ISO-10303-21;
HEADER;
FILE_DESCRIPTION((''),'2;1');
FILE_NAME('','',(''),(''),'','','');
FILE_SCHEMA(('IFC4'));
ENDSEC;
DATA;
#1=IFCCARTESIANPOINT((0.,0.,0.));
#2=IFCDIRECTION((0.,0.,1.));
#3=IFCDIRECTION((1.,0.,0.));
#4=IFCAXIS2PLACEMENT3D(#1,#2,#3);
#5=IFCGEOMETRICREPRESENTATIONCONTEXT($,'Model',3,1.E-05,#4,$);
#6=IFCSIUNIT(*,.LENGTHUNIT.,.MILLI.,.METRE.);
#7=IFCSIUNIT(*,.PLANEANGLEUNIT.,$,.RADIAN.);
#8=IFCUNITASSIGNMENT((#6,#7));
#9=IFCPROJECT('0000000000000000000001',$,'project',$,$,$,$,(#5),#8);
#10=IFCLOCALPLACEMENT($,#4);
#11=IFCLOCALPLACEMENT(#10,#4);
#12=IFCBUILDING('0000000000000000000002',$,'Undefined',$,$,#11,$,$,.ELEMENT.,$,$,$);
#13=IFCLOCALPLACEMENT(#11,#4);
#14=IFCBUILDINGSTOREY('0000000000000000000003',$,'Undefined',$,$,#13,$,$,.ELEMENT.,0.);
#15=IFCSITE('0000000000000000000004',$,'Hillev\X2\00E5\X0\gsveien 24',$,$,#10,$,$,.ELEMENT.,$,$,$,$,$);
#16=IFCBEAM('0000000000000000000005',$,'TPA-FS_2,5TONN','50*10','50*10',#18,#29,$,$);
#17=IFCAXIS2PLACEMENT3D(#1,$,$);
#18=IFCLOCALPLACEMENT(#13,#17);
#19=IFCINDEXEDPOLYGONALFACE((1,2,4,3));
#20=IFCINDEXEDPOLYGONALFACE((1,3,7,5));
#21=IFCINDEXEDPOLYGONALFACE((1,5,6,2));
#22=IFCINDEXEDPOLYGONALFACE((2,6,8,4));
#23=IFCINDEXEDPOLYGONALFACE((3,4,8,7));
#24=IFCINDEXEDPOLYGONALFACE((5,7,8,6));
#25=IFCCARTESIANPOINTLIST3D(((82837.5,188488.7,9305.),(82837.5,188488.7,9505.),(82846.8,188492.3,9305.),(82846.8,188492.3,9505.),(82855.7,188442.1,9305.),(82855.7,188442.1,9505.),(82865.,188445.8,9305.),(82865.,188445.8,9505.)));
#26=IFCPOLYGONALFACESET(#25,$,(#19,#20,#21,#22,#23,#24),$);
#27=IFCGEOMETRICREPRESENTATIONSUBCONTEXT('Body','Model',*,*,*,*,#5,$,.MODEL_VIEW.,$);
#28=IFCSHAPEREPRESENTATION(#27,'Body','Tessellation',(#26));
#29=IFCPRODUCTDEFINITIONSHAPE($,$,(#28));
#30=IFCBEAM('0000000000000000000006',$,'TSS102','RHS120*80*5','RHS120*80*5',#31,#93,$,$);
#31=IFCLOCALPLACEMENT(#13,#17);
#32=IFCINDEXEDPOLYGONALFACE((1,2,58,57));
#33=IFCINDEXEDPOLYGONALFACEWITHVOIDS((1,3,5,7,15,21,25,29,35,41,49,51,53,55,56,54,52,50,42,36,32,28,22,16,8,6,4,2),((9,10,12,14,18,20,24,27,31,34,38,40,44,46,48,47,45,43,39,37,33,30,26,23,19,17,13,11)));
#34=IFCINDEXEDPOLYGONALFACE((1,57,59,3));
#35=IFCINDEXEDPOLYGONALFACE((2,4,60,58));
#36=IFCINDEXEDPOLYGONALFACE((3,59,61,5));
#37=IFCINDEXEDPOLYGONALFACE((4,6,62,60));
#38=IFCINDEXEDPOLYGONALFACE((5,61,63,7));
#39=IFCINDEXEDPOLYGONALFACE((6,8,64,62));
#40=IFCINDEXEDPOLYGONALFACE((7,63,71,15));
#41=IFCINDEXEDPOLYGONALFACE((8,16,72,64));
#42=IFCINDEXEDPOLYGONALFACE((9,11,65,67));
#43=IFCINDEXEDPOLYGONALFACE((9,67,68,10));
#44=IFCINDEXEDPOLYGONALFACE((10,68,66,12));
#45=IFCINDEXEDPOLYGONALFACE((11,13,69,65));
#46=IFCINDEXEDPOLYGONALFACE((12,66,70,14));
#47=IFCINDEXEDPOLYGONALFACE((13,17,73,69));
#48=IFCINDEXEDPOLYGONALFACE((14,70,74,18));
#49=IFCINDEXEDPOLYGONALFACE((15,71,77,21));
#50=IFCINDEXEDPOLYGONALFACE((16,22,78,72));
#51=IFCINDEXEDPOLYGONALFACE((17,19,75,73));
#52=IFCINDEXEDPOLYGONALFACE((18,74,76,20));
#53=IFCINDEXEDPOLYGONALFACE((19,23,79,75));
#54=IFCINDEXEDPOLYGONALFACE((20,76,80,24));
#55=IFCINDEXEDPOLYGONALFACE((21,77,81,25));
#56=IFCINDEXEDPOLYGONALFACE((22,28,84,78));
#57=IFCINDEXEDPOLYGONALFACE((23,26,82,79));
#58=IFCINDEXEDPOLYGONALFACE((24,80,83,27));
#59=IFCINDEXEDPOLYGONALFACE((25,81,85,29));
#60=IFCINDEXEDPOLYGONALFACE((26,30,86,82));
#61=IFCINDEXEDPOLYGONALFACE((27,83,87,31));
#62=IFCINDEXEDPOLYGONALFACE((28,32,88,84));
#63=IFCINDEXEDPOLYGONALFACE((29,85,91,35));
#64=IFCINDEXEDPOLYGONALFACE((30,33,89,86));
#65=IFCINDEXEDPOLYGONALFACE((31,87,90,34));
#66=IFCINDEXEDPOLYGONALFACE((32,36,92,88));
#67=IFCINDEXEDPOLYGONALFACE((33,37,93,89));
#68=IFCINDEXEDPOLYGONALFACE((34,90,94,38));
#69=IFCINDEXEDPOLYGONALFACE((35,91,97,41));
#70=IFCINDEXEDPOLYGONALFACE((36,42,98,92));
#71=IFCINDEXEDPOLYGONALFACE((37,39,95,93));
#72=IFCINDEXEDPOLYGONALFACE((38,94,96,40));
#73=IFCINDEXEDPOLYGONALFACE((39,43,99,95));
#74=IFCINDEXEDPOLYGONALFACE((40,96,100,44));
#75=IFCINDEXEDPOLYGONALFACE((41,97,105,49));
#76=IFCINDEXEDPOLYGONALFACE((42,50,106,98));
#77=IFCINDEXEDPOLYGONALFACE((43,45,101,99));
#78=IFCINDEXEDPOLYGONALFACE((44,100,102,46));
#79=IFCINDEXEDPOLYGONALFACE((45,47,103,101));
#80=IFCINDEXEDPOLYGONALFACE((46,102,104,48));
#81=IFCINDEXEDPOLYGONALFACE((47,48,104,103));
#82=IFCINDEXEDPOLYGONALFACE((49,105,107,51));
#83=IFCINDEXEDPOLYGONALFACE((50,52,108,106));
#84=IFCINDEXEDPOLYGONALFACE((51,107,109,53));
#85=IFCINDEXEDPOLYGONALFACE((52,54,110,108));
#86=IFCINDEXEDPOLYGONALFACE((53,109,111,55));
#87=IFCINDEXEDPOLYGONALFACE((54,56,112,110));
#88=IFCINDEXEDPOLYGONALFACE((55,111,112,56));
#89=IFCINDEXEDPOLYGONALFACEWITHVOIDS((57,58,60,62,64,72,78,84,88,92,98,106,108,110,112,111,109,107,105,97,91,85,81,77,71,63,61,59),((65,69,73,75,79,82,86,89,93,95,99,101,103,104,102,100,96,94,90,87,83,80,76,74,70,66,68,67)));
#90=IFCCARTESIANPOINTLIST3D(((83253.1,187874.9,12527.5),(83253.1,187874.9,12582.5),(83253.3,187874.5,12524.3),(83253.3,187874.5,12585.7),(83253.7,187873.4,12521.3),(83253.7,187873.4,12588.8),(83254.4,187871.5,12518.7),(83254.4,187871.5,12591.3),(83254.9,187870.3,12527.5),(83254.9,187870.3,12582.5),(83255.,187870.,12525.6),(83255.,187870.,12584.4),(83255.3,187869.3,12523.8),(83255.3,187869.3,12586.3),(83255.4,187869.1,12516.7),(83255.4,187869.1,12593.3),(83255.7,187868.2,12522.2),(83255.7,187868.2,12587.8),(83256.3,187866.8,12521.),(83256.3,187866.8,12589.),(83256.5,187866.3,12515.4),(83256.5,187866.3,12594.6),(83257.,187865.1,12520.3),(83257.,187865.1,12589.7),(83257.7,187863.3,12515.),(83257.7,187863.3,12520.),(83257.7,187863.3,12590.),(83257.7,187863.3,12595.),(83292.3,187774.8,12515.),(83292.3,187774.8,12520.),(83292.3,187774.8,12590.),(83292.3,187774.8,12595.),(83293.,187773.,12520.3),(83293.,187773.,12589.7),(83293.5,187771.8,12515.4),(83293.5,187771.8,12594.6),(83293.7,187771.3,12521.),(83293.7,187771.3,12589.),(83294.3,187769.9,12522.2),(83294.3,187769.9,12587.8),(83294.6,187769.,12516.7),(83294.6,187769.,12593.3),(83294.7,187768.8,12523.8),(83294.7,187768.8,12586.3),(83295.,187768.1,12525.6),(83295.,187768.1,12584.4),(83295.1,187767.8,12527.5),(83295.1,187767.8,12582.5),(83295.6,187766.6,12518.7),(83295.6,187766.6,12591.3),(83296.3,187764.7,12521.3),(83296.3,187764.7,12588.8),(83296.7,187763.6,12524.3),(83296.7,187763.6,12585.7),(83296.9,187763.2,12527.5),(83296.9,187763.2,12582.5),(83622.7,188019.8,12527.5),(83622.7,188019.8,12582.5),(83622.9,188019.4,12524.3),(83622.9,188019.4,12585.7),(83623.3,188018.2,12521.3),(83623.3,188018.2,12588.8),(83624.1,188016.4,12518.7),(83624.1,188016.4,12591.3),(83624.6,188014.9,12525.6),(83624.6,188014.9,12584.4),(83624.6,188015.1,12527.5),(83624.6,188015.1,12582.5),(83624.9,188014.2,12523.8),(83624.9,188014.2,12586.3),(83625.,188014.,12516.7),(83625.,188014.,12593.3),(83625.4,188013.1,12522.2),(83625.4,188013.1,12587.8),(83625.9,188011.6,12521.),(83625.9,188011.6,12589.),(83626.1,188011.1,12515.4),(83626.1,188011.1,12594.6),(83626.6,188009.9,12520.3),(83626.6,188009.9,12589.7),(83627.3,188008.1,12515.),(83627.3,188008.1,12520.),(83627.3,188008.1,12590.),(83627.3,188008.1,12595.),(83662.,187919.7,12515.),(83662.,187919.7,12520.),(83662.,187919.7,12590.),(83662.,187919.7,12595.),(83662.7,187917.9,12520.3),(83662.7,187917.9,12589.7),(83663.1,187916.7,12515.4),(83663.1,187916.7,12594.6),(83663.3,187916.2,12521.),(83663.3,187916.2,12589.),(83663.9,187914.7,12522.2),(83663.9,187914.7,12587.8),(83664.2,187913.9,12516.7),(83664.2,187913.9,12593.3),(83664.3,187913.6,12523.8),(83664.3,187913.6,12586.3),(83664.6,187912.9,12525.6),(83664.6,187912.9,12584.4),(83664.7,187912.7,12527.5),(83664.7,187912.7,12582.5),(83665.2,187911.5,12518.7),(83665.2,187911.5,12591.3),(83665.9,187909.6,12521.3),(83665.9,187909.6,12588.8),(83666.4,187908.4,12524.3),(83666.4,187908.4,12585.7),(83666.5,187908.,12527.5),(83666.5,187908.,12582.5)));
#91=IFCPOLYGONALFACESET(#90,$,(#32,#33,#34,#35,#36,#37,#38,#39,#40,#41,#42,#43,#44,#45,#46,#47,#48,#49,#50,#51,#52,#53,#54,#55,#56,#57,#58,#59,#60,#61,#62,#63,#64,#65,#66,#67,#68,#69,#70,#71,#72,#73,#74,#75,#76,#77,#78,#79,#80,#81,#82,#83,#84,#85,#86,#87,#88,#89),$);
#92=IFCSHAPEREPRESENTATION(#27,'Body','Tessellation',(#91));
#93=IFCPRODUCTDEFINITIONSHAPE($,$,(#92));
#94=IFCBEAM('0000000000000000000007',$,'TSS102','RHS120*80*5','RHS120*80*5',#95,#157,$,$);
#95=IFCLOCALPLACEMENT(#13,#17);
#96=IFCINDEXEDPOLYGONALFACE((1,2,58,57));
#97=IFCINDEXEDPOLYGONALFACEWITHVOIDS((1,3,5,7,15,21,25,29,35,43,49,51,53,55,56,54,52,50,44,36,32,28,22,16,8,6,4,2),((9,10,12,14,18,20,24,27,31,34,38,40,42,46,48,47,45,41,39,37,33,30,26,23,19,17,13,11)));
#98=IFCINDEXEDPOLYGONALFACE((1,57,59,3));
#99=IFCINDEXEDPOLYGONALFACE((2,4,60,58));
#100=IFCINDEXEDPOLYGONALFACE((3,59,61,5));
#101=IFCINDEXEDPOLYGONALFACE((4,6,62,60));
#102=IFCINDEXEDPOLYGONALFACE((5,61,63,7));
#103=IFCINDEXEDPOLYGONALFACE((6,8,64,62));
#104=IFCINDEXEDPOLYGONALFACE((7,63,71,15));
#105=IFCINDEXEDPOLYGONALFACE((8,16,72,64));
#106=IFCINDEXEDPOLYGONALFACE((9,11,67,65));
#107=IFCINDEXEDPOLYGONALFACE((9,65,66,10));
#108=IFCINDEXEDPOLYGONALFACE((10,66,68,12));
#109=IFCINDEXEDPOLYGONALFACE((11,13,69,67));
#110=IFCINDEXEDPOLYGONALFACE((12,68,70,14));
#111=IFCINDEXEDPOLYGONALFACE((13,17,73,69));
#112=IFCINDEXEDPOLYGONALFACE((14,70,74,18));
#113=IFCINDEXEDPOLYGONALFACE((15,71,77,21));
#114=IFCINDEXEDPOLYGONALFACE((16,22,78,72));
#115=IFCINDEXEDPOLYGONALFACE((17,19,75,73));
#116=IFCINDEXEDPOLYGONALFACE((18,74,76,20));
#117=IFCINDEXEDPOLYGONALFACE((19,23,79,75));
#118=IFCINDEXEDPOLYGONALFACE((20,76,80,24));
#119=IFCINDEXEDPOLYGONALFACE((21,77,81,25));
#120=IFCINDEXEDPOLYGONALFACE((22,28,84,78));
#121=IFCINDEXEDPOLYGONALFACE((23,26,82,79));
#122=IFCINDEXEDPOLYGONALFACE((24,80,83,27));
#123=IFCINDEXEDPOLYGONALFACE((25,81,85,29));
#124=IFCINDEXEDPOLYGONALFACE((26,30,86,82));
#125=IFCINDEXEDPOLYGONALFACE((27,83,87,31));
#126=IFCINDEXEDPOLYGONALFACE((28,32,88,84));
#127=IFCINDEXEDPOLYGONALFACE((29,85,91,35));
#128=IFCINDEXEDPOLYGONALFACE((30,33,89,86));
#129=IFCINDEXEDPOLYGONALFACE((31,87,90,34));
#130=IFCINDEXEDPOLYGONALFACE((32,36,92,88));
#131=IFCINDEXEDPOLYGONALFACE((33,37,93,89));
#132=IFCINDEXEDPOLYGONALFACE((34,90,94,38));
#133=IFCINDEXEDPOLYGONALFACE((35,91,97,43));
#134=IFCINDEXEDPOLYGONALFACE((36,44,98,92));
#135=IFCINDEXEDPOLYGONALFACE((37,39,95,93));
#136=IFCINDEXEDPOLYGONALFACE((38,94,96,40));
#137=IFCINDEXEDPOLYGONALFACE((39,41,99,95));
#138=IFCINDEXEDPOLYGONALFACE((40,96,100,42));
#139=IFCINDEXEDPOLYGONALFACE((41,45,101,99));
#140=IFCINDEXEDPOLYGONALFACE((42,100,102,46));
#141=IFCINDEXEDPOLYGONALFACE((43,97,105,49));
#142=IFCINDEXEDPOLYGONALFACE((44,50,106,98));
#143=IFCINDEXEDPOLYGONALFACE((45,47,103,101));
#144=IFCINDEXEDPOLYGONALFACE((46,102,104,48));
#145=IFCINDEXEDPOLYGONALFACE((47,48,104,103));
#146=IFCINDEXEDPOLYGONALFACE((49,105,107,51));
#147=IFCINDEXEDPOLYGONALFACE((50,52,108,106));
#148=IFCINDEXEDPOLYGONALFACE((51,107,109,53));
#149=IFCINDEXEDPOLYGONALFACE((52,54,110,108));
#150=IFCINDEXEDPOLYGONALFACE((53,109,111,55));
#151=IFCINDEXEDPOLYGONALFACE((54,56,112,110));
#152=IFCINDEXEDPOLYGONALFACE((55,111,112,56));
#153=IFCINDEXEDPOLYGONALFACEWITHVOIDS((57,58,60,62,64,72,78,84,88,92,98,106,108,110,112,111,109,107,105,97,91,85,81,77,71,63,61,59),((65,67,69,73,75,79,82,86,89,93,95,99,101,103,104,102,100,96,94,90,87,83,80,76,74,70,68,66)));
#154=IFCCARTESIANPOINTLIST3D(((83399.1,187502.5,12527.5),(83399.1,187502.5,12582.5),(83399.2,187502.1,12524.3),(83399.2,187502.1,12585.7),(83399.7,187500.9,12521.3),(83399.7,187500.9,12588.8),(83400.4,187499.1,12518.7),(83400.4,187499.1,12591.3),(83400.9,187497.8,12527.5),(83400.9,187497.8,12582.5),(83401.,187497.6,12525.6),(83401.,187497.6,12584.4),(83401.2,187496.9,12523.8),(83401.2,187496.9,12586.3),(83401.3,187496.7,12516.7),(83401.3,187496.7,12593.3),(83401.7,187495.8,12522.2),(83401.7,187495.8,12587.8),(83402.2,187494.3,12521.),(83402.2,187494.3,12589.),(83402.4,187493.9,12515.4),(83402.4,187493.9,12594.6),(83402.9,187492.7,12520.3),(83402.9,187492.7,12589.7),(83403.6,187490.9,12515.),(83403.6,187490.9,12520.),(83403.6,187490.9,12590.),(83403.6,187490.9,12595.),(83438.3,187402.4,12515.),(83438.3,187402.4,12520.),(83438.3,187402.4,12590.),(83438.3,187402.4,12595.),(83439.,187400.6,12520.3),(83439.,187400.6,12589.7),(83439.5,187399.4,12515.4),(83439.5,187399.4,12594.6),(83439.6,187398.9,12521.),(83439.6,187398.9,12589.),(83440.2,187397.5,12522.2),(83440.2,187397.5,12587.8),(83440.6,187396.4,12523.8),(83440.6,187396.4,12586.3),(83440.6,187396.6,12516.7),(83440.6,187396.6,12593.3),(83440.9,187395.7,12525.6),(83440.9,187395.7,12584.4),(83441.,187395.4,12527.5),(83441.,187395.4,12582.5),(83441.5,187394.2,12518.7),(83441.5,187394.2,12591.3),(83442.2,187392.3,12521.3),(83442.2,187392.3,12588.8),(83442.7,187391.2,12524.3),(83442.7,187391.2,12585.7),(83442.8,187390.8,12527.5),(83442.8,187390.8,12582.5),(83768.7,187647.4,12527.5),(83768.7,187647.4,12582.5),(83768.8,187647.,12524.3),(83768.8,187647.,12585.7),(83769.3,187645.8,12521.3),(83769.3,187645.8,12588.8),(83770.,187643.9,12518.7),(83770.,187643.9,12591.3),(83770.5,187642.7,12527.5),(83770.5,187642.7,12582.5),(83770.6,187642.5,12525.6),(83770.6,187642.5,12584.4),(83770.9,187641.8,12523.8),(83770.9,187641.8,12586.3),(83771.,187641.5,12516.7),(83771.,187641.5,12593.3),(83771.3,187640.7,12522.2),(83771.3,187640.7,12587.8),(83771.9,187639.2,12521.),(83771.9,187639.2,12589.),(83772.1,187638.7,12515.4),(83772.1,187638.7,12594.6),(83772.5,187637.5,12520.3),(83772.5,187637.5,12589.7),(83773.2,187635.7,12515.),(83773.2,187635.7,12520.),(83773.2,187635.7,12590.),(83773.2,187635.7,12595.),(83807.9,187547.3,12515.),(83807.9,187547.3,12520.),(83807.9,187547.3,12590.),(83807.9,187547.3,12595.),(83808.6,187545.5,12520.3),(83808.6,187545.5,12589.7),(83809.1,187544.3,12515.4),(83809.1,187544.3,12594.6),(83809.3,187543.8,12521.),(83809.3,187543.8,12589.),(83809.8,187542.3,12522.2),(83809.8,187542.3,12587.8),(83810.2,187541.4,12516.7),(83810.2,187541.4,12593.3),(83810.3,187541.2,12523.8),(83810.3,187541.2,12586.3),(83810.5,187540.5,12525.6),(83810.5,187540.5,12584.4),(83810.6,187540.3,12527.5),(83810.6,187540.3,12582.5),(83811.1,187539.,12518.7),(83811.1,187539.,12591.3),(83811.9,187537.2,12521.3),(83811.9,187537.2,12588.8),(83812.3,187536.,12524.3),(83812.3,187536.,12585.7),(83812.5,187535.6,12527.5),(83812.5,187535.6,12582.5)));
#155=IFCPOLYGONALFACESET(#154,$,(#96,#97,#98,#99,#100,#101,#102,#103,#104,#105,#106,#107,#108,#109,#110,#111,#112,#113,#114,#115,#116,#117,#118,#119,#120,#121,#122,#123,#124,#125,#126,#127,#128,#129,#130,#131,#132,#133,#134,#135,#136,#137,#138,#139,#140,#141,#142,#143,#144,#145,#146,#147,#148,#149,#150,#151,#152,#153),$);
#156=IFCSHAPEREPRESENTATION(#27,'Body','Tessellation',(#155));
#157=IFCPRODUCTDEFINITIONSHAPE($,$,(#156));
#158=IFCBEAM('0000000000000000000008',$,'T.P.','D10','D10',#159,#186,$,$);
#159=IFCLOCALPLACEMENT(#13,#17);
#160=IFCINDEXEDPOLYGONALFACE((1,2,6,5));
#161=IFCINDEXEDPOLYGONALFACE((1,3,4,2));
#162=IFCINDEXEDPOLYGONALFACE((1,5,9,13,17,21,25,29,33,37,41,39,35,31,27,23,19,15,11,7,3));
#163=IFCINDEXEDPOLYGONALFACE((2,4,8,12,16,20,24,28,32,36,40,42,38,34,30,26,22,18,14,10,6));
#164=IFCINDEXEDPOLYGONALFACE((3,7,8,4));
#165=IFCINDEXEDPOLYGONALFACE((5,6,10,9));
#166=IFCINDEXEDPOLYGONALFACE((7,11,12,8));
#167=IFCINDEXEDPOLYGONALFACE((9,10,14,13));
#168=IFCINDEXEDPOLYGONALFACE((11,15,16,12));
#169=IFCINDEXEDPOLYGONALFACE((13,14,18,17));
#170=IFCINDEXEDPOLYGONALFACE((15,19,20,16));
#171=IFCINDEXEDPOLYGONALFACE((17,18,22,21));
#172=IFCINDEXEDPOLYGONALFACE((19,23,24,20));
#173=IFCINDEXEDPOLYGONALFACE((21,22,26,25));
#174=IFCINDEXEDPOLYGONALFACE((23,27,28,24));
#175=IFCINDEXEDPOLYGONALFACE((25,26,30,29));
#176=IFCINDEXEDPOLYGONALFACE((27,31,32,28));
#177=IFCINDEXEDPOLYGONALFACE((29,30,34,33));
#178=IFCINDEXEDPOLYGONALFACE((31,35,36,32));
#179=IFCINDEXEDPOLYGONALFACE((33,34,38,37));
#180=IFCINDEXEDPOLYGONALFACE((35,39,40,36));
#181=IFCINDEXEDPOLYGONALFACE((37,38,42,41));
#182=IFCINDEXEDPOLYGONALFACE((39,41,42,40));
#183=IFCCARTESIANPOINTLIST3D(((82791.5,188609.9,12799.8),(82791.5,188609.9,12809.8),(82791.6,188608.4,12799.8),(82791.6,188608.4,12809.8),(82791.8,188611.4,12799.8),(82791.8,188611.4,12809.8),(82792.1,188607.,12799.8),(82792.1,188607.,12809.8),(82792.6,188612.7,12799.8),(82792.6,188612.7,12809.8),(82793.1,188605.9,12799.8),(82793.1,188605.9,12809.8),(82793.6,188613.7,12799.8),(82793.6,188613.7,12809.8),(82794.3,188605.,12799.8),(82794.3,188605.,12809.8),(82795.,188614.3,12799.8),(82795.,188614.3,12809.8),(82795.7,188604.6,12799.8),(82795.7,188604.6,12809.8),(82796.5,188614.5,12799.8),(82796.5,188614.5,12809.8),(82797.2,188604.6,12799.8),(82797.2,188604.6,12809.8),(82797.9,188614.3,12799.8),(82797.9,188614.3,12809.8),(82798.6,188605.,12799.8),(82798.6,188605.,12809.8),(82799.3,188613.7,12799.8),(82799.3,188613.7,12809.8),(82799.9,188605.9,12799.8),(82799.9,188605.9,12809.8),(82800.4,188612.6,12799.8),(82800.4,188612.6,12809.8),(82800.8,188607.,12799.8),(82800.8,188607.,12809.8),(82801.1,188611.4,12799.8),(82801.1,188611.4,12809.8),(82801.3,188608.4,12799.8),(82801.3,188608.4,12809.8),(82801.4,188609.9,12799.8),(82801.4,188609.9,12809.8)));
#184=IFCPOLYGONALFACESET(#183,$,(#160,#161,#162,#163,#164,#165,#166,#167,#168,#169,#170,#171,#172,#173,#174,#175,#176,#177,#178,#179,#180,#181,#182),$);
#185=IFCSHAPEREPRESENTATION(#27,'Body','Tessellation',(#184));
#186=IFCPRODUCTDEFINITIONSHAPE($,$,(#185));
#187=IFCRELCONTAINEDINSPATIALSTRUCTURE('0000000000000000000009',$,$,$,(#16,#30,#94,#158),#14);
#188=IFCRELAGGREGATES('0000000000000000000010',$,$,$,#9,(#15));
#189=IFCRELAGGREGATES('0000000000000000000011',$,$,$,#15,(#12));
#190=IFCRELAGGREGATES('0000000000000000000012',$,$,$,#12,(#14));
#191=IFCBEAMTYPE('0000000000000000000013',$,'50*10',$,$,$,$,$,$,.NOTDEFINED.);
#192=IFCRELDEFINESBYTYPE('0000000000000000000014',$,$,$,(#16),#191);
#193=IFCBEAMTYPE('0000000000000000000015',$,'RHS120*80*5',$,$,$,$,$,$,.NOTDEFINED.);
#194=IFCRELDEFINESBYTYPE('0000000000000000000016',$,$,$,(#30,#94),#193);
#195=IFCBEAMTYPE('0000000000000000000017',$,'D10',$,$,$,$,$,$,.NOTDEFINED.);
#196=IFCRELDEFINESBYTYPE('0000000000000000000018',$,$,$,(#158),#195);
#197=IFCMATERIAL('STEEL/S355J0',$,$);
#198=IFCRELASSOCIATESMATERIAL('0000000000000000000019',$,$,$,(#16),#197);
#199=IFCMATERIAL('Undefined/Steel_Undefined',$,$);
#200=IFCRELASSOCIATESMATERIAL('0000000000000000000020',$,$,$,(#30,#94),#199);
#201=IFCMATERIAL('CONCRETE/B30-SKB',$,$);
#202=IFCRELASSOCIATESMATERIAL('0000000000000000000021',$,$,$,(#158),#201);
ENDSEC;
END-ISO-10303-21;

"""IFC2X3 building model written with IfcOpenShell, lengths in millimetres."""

from ifc_helpers import new_model, si_unit, frame, frame_2d, origin_with_axes, place, context, subcontext, project, spatial, rectangle, hollow_rectangle, circle, extrude, material, type_object, element, save


model = new_model("IFC2X3")

# Units and contexts
model_context = context("Model", 3, precision=1e-05, world=origin_with_axes())
body_context = subcontext(model_context, "Body", "Model", "MODEL_VIEW")
ifc_project = project(units=[si_unit("LENGTHUNIT", "METRE", prefix="MILLI"), si_unit("PLANEANGLEUNIT", "RADIAN")], contexts=[model_context])

# Site, building, storey
site_placement = place(None, origin_with_axes())
site = spatial("IfcSite", under=ifc_project, at=site_placement, Name="Hillevågsveien 24", CompositionType="ELEMENT")
building_placement = place(site_placement, origin_with_axes())
building = spatial("IfcBuilding", under=site, at=building_placement, Name="Undefined", CompositionType="ELEMENT")
storey_placement = place(building_placement, origin_with_axes())
storey = spatial("IfcBuildingStorey", under=building, at=storey_placement, Name="Undefined", CompositionType="ELEMENT", Elevation=0.0)

# Beams
ifc_material_1 = material(Name="Undefined/Steel_Undefined")
ifc_material_2 = material(Name="STEEL/S355J0")
beam_type_1 = type_object("IfcBeamType", Name="50*10", PredefinedType="NOTDEFINED")
for number, where, z_axis, x_axis, name in (
    (1, (82851.3, 188467.2, 9505.0), (-0.364877, 0.931056, 0.0), (0.0, 0.0, -1.0), "TPA-FS_2,5TONN"),
):
    element("IfcBeam", number, at=place(storey_placement, frame(where, z_axis=z_axis, x_axis=x_axis)), inside=storey, type_object=beam_type_1, material=ifc_material_2, Name=name, Description="50*10", ObjectType="50*10", context=body_context, shape_type="SweptSolid", body=[
        extrude(rectangle(XDim=10.0, YDim=50.0, at=frame_2d((0.0, 0.0), x_axis=(1.0, 0.0))), frame((200.0, 0.0, 0.0), z_axis=(-1.0, 0.0, 0.0), x_axis=(0.0, -1.0, 0.0)), (0.0, 0.0, 1.0), 200.0),
    ])
beam_type_2 = type_object("IfcBeamType", Name="RHS120*80*5", PredefinedType="NOTDEFINED")
for number, where, z_axis, x_axis, name in (
    (2, (83644.6, 187963.9, 12555.0), (0.364887, -0.931052, 0.0), (-0.931052, -0.364887, 0.0), "TSS102"),
    (3, (83790.6, 187591.5, 12555.0), (0.364887, -0.931052, 0.0), (-0.931052, -0.364887, 0.0), "TSS102"),
):
    element("IfcBeam", number, at=place(storey_placement, frame(where, z_axis=z_axis, x_axis=x_axis)), inside=storey, type_object=beam_type_2, material=ifc_material_1, Name=name, Description="RHS120*80*5", ObjectType="RHS120*80*5", context=body_context, shape_type="SweptSolid", body=[
        extrude(hollow_rectangle(XDim=80.0, YDim=120.0, WallThickness=5.0, InnerFilletRadius=7.5, OuterFilletRadius=12.5, at=frame_2d((0.0, 0.0), x_axis=(1.0, 0.0))), frame((397.0, 0.0, 0.0), z_axis=(-1.0, 0.0, 0.0), x_axis=(0.0, -1.0, 0.0)), (0.0, 0.0, 1.0), 397.0),
    ])
ifc_material_3 = material(Name="CONCRETE/B30-SKB")
beam_type_3 = type_object("IfcBeamType", Name="D10", PredefinedType="NOTDEFINED")
for number, where, z_axis, x_axis, name in (
    (4, (82796.5, 188609.5, 12809.8), (-0.364877, 0.931056, 0.0), (0.0, 0.0, -1.0), "T.P."),
):
    element("IfcBeam", number, at=place(storey_placement, frame(where, z_axis=z_axis, x_axis=x_axis)), inside=storey, type_object=beam_type_3, material=ifc_material_3, Name=name, Description="D10", ObjectType="D10", context=body_context, shape_type="SweptSolid", body=[
        extrude(circle(Radius=5.0, at=frame_2d((0.0, 0.0), x_axis=(1.0, 0.0))), frame((10.0, 0.0, 0.0), z_axis=(-1.0, 0.0, 0.0), x_axis=(0.0, -1.0, 0.0)), (0.0, 0.0, 1.0), 10.0),
    ])

save(model, "model.ifc")
